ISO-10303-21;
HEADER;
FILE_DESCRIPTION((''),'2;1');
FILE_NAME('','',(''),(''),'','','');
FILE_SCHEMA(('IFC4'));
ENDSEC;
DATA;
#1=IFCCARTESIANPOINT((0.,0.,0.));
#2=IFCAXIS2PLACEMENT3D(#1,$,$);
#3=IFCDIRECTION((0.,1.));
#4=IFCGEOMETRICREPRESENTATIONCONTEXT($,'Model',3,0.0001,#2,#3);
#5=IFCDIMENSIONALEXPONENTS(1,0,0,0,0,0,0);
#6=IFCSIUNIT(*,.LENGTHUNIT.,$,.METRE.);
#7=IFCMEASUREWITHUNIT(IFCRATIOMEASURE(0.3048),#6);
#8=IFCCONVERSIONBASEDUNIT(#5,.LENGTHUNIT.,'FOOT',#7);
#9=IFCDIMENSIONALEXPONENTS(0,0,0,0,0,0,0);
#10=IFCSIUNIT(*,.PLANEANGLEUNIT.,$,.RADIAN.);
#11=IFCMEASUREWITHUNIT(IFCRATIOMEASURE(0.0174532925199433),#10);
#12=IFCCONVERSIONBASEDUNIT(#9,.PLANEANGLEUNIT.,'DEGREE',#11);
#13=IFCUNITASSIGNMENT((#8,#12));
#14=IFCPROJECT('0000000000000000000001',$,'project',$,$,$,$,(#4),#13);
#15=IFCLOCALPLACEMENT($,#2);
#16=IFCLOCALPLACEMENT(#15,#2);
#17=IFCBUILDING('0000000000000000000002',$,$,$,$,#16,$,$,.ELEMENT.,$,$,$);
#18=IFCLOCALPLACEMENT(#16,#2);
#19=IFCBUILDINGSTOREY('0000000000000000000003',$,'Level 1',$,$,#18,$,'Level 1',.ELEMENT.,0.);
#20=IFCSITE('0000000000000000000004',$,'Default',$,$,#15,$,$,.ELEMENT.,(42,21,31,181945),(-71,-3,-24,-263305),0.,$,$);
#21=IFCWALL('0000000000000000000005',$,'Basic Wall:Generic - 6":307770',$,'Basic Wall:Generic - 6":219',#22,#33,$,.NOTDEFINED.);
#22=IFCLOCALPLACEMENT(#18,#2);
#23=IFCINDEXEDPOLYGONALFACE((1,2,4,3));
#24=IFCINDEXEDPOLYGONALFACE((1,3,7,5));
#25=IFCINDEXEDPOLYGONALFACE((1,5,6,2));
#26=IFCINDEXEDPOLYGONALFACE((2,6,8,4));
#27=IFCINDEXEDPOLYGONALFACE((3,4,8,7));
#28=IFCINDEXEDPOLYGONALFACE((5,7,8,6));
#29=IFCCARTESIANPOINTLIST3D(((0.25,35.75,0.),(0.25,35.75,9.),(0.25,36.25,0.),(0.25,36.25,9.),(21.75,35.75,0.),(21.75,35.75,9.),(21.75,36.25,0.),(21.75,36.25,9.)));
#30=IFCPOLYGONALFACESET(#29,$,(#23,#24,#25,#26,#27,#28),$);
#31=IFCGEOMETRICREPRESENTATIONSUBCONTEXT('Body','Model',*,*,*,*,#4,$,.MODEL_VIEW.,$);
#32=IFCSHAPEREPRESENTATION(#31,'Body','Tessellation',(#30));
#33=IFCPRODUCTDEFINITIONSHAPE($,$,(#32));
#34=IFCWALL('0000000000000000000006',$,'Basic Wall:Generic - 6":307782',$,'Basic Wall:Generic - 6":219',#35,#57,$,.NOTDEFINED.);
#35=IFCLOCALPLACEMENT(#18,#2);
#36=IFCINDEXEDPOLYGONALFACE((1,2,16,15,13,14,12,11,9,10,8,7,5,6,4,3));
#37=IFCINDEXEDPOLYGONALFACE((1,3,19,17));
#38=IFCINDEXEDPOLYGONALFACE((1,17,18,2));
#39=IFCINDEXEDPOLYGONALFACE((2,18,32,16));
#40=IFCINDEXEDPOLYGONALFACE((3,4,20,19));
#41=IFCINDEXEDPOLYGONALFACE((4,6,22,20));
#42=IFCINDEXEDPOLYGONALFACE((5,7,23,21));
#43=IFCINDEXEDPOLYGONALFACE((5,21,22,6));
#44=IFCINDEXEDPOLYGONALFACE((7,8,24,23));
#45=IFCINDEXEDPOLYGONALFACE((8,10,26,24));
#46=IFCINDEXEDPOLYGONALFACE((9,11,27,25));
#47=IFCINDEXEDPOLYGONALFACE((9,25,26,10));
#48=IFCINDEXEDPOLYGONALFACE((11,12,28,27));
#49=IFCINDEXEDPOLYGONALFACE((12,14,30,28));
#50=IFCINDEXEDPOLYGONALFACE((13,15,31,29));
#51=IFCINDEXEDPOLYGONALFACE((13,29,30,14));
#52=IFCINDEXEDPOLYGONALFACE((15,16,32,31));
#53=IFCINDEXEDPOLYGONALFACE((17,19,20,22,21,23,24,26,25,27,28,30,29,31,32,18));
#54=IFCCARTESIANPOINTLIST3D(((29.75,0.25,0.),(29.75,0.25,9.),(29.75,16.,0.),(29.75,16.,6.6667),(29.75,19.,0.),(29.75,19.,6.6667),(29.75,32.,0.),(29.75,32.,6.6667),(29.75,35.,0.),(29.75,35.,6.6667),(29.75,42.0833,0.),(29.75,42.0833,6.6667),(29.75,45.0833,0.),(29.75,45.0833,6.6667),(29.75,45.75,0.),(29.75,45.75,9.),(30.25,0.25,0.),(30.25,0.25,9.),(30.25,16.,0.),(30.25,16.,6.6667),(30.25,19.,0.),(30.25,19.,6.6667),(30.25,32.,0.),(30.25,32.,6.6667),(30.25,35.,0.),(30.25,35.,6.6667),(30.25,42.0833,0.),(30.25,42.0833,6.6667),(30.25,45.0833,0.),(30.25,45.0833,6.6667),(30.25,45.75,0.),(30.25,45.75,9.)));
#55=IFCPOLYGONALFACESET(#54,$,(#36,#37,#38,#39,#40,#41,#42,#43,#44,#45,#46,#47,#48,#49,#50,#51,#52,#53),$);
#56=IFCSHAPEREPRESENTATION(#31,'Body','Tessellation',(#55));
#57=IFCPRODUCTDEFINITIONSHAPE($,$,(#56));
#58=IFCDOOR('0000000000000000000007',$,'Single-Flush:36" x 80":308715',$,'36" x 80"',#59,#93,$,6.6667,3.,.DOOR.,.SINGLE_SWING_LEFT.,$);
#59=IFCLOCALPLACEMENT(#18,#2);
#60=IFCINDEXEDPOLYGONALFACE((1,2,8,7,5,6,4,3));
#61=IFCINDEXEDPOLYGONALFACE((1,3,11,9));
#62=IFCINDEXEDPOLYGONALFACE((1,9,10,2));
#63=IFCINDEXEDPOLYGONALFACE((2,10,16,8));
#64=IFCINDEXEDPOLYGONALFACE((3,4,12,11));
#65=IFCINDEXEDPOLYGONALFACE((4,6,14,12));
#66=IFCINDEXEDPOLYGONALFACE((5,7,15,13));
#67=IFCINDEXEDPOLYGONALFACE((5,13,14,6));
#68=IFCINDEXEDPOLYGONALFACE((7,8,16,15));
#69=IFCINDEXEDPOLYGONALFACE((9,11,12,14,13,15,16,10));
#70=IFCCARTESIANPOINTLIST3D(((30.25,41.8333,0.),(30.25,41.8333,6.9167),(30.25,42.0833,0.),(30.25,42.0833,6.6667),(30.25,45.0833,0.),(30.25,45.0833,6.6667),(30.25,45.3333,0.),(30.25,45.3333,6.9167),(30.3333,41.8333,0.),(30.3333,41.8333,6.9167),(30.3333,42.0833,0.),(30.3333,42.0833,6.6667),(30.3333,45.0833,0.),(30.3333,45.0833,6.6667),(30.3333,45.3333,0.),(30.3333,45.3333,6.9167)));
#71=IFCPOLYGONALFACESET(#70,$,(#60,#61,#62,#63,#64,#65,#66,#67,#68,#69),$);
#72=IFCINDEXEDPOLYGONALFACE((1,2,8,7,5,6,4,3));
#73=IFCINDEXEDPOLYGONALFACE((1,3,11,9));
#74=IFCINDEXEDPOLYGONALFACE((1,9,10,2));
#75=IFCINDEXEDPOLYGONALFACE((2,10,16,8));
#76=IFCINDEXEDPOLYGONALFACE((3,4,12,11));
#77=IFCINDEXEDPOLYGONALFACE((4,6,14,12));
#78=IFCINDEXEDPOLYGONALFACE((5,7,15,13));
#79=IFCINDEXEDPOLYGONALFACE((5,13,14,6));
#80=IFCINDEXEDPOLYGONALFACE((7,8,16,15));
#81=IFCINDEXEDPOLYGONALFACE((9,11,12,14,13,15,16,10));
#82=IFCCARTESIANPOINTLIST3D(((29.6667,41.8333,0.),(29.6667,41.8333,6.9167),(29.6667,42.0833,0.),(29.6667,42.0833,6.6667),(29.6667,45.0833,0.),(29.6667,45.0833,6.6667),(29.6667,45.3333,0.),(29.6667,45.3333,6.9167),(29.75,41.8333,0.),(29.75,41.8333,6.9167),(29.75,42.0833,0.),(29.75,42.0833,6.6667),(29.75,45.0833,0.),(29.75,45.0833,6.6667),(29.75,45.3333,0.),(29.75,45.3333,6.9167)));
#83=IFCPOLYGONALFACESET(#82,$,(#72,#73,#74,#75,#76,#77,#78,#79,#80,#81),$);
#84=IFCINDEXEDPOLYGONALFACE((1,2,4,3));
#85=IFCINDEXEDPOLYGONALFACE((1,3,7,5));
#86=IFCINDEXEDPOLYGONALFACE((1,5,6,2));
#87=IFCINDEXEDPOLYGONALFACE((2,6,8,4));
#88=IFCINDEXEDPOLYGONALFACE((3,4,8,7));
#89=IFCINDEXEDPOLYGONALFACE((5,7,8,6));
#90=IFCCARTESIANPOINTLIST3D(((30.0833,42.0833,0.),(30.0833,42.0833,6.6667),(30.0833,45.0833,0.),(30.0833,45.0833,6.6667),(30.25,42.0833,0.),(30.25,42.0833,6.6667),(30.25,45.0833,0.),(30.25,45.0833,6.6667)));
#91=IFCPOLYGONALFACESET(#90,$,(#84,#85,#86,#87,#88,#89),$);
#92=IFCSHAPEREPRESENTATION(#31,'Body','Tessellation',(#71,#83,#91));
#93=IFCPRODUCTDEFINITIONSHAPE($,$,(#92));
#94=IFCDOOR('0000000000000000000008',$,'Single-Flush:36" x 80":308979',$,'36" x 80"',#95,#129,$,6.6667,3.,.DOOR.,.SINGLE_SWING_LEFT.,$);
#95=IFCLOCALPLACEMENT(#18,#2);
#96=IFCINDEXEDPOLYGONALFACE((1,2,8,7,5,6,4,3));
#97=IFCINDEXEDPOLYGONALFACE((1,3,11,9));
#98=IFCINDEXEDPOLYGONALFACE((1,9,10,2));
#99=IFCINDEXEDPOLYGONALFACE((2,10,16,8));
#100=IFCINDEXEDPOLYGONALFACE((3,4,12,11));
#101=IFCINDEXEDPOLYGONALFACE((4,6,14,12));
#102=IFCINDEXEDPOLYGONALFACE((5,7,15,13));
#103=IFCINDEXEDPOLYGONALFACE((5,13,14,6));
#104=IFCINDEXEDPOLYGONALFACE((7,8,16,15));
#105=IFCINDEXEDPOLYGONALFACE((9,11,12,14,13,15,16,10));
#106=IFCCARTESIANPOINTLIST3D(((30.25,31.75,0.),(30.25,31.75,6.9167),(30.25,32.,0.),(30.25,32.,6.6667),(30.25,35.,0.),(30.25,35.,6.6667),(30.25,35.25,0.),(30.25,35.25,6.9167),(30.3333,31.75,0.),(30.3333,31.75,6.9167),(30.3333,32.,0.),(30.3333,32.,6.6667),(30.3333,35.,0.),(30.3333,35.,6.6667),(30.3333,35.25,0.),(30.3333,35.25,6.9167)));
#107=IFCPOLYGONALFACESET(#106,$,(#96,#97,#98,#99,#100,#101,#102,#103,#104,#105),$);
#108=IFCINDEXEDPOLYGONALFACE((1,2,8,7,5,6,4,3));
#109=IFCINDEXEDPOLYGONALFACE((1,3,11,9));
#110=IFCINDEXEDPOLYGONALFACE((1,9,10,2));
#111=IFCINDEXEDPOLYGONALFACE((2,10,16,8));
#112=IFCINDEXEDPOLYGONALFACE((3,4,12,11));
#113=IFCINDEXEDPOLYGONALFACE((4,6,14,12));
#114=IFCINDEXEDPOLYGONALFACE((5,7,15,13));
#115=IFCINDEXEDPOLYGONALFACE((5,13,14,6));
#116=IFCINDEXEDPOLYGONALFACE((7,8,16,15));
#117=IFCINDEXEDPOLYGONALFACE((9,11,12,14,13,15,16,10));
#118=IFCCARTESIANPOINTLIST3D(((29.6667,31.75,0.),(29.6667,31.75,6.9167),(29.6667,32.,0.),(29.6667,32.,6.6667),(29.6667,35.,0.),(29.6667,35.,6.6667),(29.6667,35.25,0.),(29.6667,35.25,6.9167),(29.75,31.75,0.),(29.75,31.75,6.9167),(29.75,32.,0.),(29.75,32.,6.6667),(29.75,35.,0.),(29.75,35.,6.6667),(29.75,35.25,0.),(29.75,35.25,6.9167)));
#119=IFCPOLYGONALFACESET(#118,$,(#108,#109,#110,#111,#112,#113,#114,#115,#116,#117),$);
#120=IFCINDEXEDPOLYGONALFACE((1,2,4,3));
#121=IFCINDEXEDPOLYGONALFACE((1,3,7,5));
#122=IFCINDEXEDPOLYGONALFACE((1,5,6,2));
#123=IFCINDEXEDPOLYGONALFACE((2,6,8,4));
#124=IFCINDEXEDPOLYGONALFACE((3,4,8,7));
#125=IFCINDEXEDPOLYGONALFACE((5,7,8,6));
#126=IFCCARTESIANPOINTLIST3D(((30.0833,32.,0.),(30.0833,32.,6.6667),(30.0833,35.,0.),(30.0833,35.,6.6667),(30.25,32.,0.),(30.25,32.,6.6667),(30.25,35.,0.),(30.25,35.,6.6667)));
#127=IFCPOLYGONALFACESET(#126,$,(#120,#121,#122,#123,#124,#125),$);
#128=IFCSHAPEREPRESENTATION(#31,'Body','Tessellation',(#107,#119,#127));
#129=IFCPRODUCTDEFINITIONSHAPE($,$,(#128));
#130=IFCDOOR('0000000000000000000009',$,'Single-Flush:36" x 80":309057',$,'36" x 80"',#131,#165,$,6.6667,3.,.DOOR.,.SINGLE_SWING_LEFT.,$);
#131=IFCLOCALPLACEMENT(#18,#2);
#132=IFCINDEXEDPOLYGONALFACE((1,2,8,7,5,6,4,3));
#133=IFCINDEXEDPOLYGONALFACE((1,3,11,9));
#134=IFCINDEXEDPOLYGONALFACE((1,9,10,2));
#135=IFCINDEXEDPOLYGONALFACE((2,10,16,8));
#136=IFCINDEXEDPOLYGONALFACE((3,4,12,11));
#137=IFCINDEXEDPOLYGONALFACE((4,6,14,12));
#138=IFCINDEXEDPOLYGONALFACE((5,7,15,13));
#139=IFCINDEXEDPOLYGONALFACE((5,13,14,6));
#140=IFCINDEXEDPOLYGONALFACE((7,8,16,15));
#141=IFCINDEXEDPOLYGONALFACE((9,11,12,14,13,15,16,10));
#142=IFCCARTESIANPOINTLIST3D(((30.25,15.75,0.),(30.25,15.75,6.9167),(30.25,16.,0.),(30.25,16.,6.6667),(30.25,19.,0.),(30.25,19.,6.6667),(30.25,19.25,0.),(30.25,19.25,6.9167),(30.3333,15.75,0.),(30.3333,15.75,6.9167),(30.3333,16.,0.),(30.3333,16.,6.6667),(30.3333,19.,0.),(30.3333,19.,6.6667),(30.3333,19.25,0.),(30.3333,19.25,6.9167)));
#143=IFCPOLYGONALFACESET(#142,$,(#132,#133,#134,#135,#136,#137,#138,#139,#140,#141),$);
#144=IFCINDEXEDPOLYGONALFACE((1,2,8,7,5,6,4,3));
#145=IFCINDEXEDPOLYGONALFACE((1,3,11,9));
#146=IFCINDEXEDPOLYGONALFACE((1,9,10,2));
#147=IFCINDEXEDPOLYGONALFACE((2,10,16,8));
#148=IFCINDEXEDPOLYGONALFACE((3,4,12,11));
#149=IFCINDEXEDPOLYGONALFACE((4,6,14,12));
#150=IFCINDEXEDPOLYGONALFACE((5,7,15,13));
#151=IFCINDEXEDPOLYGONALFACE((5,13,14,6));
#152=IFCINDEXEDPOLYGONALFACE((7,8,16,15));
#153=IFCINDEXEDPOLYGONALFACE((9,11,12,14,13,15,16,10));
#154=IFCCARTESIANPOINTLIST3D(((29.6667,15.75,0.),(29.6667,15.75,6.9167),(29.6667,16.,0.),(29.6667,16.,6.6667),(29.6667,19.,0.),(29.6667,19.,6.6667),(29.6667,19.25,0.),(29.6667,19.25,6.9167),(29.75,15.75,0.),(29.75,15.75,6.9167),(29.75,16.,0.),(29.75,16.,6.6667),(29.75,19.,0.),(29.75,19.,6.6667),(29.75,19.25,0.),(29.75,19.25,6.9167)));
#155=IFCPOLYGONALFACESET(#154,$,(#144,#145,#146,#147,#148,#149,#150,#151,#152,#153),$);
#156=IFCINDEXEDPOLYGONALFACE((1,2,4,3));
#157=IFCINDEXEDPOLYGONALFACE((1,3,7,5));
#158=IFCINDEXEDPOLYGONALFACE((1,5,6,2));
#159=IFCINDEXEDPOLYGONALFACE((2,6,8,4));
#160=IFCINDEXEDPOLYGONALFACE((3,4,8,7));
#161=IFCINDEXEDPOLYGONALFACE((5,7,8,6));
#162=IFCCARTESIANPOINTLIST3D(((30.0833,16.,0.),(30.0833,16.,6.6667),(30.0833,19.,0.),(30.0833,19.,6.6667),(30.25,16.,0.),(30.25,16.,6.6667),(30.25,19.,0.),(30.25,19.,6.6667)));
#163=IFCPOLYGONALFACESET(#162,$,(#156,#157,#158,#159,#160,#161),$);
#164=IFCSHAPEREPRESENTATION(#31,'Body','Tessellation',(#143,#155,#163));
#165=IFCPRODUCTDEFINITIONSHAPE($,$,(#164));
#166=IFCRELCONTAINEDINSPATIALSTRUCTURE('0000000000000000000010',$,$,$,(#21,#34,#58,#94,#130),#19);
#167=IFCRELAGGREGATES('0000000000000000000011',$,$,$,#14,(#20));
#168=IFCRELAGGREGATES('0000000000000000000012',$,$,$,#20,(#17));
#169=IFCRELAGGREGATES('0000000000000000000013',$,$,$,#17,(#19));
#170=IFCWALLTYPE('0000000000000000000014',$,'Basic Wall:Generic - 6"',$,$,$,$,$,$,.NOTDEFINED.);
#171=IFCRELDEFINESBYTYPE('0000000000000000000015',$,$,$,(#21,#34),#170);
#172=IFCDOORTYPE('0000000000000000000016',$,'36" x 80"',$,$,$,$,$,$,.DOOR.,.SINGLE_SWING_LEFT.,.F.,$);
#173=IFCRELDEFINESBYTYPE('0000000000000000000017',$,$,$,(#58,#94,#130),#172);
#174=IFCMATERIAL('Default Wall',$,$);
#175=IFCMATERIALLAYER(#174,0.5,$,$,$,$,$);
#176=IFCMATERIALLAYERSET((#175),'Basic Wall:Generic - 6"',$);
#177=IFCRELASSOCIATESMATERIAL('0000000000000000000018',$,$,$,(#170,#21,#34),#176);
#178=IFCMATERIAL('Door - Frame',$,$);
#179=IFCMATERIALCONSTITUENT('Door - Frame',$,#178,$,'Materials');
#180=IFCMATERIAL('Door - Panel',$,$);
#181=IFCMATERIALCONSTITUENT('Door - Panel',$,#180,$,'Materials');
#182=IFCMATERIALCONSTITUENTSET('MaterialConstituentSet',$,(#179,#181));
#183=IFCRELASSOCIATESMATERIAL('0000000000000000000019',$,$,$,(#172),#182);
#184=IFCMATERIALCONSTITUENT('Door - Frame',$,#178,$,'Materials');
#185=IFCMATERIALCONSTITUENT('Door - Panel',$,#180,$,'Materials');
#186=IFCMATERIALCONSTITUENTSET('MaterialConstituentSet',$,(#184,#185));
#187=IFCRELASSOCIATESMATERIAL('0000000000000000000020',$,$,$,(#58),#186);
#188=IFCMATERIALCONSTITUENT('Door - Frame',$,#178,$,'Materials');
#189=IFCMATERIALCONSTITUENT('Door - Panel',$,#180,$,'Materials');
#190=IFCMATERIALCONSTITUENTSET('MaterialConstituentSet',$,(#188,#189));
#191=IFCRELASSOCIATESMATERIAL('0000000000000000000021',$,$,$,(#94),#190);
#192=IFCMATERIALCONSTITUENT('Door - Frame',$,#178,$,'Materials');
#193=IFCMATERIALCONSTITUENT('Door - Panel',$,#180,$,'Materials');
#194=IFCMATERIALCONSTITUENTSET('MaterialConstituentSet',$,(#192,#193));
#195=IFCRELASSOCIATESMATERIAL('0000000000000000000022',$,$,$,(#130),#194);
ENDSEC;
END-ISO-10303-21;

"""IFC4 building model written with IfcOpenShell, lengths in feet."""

from ifc_helpers import new_model, entity, si_unit, converted_unit, direction, frame, frame_2d, origin, origin_2d_with_axis, place, context, subcontext, project, spatial, polyline, rectangle, outline, extrude, clip, bounded_halfspace, source, transform, mapped, material, layer, layer_set, layer_usage, constituent, constituent_set, type_object, type_shapes, element, fill, save


model = new_model("IFC4")

# Units and contexts
model_context = context("Model", 3, precision=0.0001, world=origin(), true_north=direction((0.0, 1.0)))
body_context = subcontext(model_context, "Body", "Model", "MODEL_VIEW")
ifc_project = project(units=[converted_unit("LENGTHUNIT", "FOOT", entity("IfcRatioMeasure", 0.3048), si_unit("LENGTHUNIT", "METRE"), dimensions=[1, 0, 0, 0, 0, 0, 0]), converted_unit("PLANEANGLEUNIT", "DEGREE", entity("IfcRatioMeasure", 0.0174532925199433), si_unit("PLANEANGLEUNIT", "RADIAN"), dimensions=[0, 0, 0, 0, 0, 0, 0])], contexts=[model_context])

# Site, building, storey
site_placement = place(None, origin())
site = spatial("IfcSite", under=ifc_project, at=site_placement, Name="Default", CompositionType="ELEMENT", RefLatitude=(42, 21, 31, 181945), RefLongitude=(-71, -3, -24, -263305), RefElevation=0.0)
building_placement = place(site_placement, origin())
building = spatial("IfcBuilding", under=site, at=building_placement, CompositionType="ELEMENT")
storey_placement = place(building_placement, origin())
storey = spatial("IfcBuildingStorey", under=building, at=storey_placement, Name="Level 1", LongName="Level 1", CompositionType="ELEMENT", Elevation=0.0)

# Shared definitions
ifc_material_1 = material(Name="Default Wall")
ifc_layer = layer(ifc_material_1, 0.5)
ifc_layer_set = layer_set([ifc_layer], Name="Basic Wall:Generic - 6\"")
wall_type = type_object("IfcWallType", Name="Basic Wall:Generic - 6\"", PredefinedType="NOTDEFINED", material=ifc_layer_set)
ifc_material_2 = material(Name="Door - Frame")
ifc_material_3 = material(Name="Door - Panel")

# Wall
ifc_layer_usage_1 = layer_usage(ifc_layer_set, "AXIS2", "NEGATIVE", 0.25)
wall_1_placement = place(storey_placement, frame((0.25, 36.0, 0.0)))
element("IfcWall", 1, at=wall_1_placement, inside=storey, type_object=wall_type, material=ifc_layer_usage_1, Name="Basic Wall:Generic - 6\":307770", ObjectType="Basic Wall:Generic - 6\":219", PredefinedType="NOTDEFINED", context=body_context, shape_type="Clipping", body=[
    clip(extrude(rectangle(XDim=21.5, YDim=0.5, at=frame_2d((10.75, 0.0), x_axis=(-1.0, 0.0))), origin(), (0.0, 0.0, 1.0), 9.0), bounded_halfspace(frame((0.0, -0.25, 9.0), z_axis=(0.0, 0.0, -1.0), x_axis=(-1.0, 0.0, 0.0)), True, frame((0.0, -0.25, 9.0)), polyline([(0.0, 0.0), (21.5, 0.0), (21.5, 0.5), (0.0, 0.5), (0.0, 0.0)]))),
])

# Wall, openings, doors
ifc_layer_usage_2 = layer_usage(ifc_layer_set, "AXIS2", "NEGATIVE", 0.25)
wall_2_placement = place(storey_placement, frame((30.0, 45.75, 0.0), z_axis=(0.0, 0.0, 1.0), x_axis=(0.0, -1.0, 0.0)))
wall_2 = element("IfcWall", 2, at=wall_2_placement, inside=storey, type_object=wall_type, material=ifc_layer_usage_2, Name="Basic Wall:Generic - 6\":307782", ObjectType="Basic Wall:Generic - 6\":219", PredefinedType="NOTDEFINED", context=body_context, shape_type="Clipping", body=[
    clip(clip(clip(extrude(rectangle(XDim=45.5, YDim=0.5, at=frame_2d((22.75, 0.0), x_axis=(-1.0, 0.0))), origin(), (0.0, 0.0, 1.0), 9.0), bounded_halfspace(frame((34.0, -0.25, 9.0), z_axis=(0.0, 0.0, -1.0), x_axis=(0.0, 1.0, 0.0)), True, frame((34.0, -0.25, 9.0)), polyline([(0.0, 0.0), (11.5, 0.0), (11.5, 0.5), (0.0, 0.5), (0.0, 0.0)]))), bounded_halfspace(frame((25.5, -0.25, 9.0), z_axis=(0.0, 0.0, -1.0), x_axis=(-1.0, 0.0, 0.0)), True, frame((25.5, -0.25, 9.0)), polyline([(0.0, 0.0), (0.0, 0.5), (-15.5, 0.5), (-16.0, 0.5), (-25.5, 0.5), (-25.5, 0.0), (0.0, 0.0)]))), bounded_halfspace(frame((34.0, -0.25, 9.0), z_axis=(0.0, 0.0, -1.0), x_axis=(1.0, 0.0, 0.0)), True, frame((34.0, -0.25, 9.0)), polyline([(0.0, 0.0), (0.0, 0.5), (-8.0, 0.5), (-8.5, 0.5), (-8.5, 0.0), (-0.5, 0.0), (0.0, 0.0)]))),
])
opening_1_placement = place(wall_2_placement, frame((0.6667, -0.25, 0.0)))
opening_1 = element("IfcOpeningElement", 3, at=opening_1_placement, cuts=wall_2, ObjectType="Opening", PredefinedType="OPENING", context=body_context, shape_type="SweptSolid", body=[
    extrude(rectangle(XDim=3.0, YDim=6.6667, at=frame_2d((3.3333, 1.5), x_axis=(0.0, -1.0))), frame((0.0, 0.0, 0.0), z_axis=(0.0, 1.0, 0.0), x_axis=(0.0, 0.0, 1.0)), (0.0, 0.0, 1.0), 0.5),
])
opening_2_placement = place(wall_2_placement, frame((10.75, -0.25, 0.0)))
opening_2 = element("IfcOpeningElement", 4, at=opening_2_placement, cuts=wall_2, ObjectType="Opening", PredefinedType="OPENING", context=body_context, shape_type="SweptSolid", body=[
    extrude(rectangle(XDim=3.0, YDim=6.6667, at=frame_2d((3.3333, 1.5), x_axis=(0.0, -1.0))), frame((0.0, 0.0, 0.0), z_axis=(0.0, 1.0, 0.0), x_axis=(0.0, 0.0, 1.0)), (0.0, 0.0, 1.0), 0.5),
])
opening_3_placement = place(wall_2_placement, frame((26.75, -0.25, 0.0)))
opening_3 = element("IfcOpeningElement", 5, at=opening_3_placement, cuts=wall_2, ObjectType="Opening", PredefinedType="OPENING", context=body_context, shape_type="SweptSolid", body=[
    extrude(rectangle(XDim=3.0, YDim=6.6667, at=frame_2d((3.3333, 1.5), x_axis=(0.0, -1.0))), frame((0.0, 0.0, 0.0), z_axis=(0.0, 1.0, 0.0), x_axis=(0.0, 0.0, 1.0)), (0.0, 0.0, 1.0), 0.5),
])
ifc_constituent_1 = constituent(ifc_material_2, Name="Door - Frame", Category="Materials")
ifc_constituent_2 = constituent(ifc_material_3, Name="Door - Panel", Category="Materials")
ifc_constituent_set_1 = constituent_set(constituents=[ifc_constituent_1, ifc_constituent_2], Name="MaterialConstituentSet")
ifc_constituent_3 = constituent(ifc_material_2, Name="Door - Frame", Category="Materials")
ifc_constituent_4 = constituent(ifc_material_3, Name="Door - Panel", Category="Materials")
ifc_constituent_set_2 = constituent_set(constituents=[ifc_constituent_3, ifc_constituent_4], Name="MaterialConstituentSet")
door_type_1 = type_object("IfcDoorType", Name="36\" x 80\"", OperationType="SINGLE_SWING_LEFT", ParameterTakesPrecedence=False, PredefinedType="DOOR", material=ifc_constituent_set_2)
shared_shape_1 = source(origin(), body_context, "Body", "SweptSolid", [
    extrude(outline(polyline([(-1.75, -3.5208), (1.75, -3.5208), (1.75, 3.3958), (1.5, 3.3958), (1.5, -3.2708), (-1.5, -3.2708), (-1.5, 3.3958), (-1.75, 3.3958), (-1.75, -3.5208)])), frame((1.5, 0.5833, 3.3958), z_axis=(0.0, -1.0, 0.0), x_axis=(-1.0, 0.0, 0.0)), (0.0, 0.0, 1.0), 0.0833),
    extrude(outline(polyline([(-3.5208, -1.75), (3.3958, -1.75), (3.3958, -1.5), (-3.2708, -1.5), (-3.2708, 1.5), (3.3958, 1.5), (3.3958, 1.75), (-3.5208, 1.75), (-3.5208, -1.75)])), frame((1.5, 0.0, 3.3958), z_axis=(0.0, -1.0, 0.0), x_axis=(0.0, 0.0, -1.0)), (0.0, 0.0, 1.0), 0.0833),
    extrude(rectangle(XDim=3.0, YDim=0.1667, at=origin_2d_with_axis()), frame((1.5, 0.4167, 0.0)), (0.0, 0.0, 1.0), 6.6667),
])
type_shapes(door_type_1, [shared_shape_1])
door_1_placement = place(opening_1_placement, origin())
door_1 = element("IfcDoor", 6, at=door_1_placement, inside=storey, type_object=door_type_1, material=ifc_constituent_set_1, Name="Single-Flush:36\" x 80\":308715", ObjectType="36\" x 80\"", OperationType="SINGLE_SWING_LEFT", OverallHeight=6.6667, OverallWidth=3.0, PredefinedType="DOOR", context=body_context, shape_type="MappedRepresentation", body=[
    mapped(shared_shape_1, transform((0.0, 0.0, 0.0), scale=1.0)),
])
fill(opening_1, door_1)
ifc_constituent_5 = constituent(ifc_material_2, Name="Door - Frame", Category="Materials")
ifc_constituent_6 = constituent(ifc_material_3, Name="Door - Panel", Category="Materials")
ifc_constituent_set_3 = constituent_set(constituents=[ifc_constituent_5, ifc_constituent_6], Name="MaterialConstituentSet")
door_2_placement = place(opening_2_placement, origin())
door_2 = element("IfcDoor", 7, at=door_2_placement, inside=storey, type_object=door_type_1, material=ifc_constituent_set_3, Name="Single-Flush:36\" x 80\":308979", ObjectType="36\" x 80\"", OperationType="SINGLE_SWING_LEFT", OverallHeight=6.6667, OverallWidth=3.0, PredefinedType="DOOR", context=body_context, shape_type="MappedRepresentation", body=[
    mapped(shared_shape_1, transform((0.0, 0.0, 0.0), scale=1.0)),
])
fill(opening_2, door_2)
ifc_constituent_7 = constituent(ifc_material_2, Name="Door - Frame", Category="Materials")
ifc_constituent_8 = constituent(ifc_material_3, Name="Door - Panel", Category="Materials")
ifc_constituent_set_4 = constituent_set(constituents=[ifc_constituent_7, ifc_constituent_8], Name="MaterialConstituentSet")
door_3_placement = place(opening_3_placement, origin())
door_3 = element("IfcDoor", 8, at=door_3_placement, inside=storey, type_object=door_type_1, material=ifc_constituent_set_4, Name="Single-Flush:36\" x 80\":309057", ObjectType="36\" x 80\"", OperationType="SINGLE_SWING_LEFT", OverallHeight=6.6667, OverallWidth=3.0, PredefinedType="DOOR", context=body_context, shape_type="MappedRepresentation", body=[
    mapped(shared_shape_1, transform((0.0, 0.0, 0.0), scale=1.0)),
])
fill(opening_3, door_3)

save(model, "model.ifc")
